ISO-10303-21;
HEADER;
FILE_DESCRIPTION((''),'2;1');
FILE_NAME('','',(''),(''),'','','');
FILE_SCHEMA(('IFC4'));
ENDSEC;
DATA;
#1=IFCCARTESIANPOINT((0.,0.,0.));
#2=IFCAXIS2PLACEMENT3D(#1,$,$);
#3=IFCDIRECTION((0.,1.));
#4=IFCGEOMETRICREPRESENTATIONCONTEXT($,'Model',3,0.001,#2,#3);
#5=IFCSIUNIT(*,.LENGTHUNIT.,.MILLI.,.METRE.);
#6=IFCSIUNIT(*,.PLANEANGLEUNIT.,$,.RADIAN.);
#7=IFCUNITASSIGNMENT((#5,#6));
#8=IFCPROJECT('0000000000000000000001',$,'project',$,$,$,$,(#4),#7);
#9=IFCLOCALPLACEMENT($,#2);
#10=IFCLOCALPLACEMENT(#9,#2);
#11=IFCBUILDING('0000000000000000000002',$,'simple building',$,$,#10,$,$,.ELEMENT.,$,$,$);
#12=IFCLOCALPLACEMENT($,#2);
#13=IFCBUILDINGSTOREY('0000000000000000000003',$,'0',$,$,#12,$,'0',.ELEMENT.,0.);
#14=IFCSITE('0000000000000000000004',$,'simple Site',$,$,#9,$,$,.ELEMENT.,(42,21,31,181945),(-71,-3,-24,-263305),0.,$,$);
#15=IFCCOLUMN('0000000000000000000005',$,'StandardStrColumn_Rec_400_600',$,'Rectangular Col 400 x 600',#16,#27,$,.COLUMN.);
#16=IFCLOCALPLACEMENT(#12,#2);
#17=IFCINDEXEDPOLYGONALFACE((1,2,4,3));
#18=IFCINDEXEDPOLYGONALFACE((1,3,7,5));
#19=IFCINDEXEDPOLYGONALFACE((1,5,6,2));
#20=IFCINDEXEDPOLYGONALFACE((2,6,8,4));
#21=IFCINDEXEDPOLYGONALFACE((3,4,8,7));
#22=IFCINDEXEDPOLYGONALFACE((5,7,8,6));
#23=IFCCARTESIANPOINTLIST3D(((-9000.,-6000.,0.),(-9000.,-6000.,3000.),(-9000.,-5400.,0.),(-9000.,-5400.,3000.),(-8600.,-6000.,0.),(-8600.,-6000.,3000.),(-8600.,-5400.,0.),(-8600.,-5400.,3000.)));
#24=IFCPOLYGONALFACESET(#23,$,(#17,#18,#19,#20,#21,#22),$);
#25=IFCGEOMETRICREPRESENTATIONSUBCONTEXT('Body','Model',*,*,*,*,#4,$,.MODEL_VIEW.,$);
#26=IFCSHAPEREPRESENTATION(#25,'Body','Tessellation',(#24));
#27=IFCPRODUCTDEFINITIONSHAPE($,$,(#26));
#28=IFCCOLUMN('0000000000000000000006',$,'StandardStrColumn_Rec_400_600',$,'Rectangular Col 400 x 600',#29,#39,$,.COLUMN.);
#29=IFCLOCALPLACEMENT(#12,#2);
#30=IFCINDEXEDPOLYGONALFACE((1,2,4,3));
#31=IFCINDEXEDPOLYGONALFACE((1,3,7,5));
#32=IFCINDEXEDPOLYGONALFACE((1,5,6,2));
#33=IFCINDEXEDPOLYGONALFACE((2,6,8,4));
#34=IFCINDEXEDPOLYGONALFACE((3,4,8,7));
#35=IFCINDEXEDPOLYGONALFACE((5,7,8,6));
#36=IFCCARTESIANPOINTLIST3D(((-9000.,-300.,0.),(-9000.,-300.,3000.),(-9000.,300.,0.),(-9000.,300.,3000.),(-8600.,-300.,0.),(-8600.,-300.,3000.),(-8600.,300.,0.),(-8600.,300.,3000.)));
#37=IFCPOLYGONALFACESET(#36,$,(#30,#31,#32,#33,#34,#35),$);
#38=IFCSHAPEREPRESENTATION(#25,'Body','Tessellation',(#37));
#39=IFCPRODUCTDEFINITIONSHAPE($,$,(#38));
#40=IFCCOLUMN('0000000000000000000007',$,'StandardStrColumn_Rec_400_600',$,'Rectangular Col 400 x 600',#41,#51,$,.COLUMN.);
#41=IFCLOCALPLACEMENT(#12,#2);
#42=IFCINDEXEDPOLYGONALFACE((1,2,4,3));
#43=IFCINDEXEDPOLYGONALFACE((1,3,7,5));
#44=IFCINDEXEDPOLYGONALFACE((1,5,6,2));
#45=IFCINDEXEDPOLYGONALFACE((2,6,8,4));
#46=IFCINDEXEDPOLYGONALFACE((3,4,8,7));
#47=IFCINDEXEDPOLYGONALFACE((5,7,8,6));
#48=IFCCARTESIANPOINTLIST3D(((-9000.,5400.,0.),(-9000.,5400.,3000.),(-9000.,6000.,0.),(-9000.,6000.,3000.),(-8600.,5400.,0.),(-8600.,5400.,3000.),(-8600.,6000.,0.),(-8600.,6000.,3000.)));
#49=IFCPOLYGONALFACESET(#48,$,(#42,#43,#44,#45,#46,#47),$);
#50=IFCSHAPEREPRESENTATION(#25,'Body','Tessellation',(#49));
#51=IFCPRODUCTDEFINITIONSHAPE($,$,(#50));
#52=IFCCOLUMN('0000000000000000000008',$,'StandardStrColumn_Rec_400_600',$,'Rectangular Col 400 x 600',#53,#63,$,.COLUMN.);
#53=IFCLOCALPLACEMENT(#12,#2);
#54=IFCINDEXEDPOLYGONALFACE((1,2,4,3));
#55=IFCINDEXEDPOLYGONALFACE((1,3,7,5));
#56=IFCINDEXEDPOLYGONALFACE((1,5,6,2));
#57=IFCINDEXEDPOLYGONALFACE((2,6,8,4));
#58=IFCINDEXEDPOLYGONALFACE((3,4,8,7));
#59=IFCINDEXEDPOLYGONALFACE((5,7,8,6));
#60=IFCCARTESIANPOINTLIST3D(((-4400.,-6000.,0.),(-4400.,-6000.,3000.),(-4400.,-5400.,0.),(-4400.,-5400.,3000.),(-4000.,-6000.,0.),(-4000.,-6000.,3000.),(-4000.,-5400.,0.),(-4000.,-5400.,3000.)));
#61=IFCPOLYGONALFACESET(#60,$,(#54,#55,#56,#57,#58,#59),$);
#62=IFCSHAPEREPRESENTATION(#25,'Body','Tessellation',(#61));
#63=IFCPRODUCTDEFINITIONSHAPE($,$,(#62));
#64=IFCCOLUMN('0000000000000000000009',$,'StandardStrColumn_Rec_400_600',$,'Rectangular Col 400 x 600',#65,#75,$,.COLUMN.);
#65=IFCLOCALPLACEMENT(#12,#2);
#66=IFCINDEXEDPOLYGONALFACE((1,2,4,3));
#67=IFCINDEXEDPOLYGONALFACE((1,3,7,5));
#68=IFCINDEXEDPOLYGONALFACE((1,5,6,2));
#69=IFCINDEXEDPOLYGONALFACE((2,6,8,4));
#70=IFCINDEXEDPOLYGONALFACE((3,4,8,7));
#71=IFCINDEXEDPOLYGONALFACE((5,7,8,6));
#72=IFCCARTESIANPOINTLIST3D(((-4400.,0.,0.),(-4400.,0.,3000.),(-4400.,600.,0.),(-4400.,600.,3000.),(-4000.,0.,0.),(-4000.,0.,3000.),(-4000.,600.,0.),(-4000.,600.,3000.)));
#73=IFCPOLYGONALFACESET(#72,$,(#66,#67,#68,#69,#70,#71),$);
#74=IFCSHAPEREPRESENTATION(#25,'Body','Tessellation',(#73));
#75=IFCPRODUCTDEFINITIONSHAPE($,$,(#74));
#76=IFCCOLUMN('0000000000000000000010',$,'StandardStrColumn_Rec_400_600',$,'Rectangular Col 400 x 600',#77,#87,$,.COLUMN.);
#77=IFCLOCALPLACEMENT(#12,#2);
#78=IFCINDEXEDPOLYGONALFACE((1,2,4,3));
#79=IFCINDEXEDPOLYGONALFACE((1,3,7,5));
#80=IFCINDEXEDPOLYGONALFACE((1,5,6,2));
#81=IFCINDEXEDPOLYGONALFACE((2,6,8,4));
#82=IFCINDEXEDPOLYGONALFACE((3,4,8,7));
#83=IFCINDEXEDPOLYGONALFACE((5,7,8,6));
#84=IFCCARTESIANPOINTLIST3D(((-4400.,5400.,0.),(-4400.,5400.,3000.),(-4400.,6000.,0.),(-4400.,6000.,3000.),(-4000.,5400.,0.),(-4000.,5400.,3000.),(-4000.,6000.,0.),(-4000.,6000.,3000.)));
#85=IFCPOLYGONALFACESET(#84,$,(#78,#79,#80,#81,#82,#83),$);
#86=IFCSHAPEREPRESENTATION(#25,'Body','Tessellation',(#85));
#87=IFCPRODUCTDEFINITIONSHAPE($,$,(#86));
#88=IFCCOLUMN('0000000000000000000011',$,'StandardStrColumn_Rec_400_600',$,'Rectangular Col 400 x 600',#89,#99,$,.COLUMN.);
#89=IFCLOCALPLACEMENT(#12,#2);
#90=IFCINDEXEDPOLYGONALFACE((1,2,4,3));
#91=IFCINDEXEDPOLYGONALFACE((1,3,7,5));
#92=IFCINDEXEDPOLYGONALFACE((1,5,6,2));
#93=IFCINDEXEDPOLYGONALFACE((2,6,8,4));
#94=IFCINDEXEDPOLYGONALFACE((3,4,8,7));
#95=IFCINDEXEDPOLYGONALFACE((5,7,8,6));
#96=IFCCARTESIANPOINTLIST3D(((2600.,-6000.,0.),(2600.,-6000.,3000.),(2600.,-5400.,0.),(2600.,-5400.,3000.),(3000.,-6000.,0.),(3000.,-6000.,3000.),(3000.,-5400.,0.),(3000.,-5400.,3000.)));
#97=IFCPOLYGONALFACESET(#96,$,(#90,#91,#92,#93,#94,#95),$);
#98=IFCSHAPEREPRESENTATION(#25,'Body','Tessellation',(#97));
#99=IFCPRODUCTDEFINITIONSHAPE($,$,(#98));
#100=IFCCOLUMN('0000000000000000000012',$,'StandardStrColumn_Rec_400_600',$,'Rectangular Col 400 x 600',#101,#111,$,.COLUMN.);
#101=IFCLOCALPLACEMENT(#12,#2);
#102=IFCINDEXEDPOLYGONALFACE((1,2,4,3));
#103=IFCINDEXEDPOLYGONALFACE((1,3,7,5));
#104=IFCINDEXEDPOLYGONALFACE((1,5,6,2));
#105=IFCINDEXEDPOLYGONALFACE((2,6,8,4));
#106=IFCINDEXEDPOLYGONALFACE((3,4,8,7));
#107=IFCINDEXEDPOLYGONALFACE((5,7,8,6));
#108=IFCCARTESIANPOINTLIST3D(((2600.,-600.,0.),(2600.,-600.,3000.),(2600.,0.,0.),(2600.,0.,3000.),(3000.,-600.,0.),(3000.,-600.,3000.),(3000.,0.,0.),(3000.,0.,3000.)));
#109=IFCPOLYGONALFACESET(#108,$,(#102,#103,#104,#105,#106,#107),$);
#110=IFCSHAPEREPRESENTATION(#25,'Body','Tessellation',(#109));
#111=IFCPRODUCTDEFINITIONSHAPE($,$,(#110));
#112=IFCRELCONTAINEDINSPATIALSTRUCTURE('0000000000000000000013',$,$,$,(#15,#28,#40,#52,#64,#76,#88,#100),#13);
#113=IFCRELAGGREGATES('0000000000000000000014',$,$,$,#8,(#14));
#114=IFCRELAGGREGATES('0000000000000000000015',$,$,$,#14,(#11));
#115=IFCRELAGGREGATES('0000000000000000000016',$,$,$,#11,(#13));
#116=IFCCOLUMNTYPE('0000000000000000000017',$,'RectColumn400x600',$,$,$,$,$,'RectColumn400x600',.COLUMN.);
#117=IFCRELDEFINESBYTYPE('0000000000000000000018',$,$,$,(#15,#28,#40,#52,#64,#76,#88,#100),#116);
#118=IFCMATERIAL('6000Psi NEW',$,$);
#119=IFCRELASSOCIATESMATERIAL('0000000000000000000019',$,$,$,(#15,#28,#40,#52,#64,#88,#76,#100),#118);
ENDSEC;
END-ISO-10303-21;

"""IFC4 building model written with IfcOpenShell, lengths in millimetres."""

from ifc_helpers import new_model, si_unit, direction, frame, origin, origin_with_axes, origin_2d_with_axis, place, context, subcontext, project, spatial, rectangle, extrude, material, material_profile, profile_set, profile_usage, type_object, element, save


model = new_model("IFC4")

# Units and contexts
model_context = context("Model", 3, precision=0.001, world=origin(), true_north=direction((0.0, 1.0)))
body_context = subcontext(model_context, "Body", "Model", "MODEL_VIEW")
ifc_project = project(units=[si_unit("LENGTHUNIT", "METRE", prefix="MILLI"), si_unit("PLANEANGLEUNIT", "RADIAN")], contexts=[model_context])

# Site, building, storey
site_placement = place(None, origin())
site = spatial("IfcSite", under=ifc_project, at=site_placement, Name="simple Site", CompositionType="ELEMENT", RefLatitude=(42, 21, 31, 181945), RefLongitude=(-71, -3, -24, -263305), RefElevation=0.0)
building_placement = place(site_placement, origin())
building = spatial("IfcBuilding", under=site, at=building_placement, Name="simple building", CompositionType="ELEMENT")
storey_placement = place(None, origin())
storey = spatial("IfcBuildingStorey", under=building, at=storey_placement, Name="0", LongName="0", CompositionType="ELEMENT", Elevation=0.0)

# Columns
ifc_material = material(Name="6000Psi NEW")
ifc_material_profile = material_profile(ifc_material, rectangle(XDim=400.0, YDim=600.0, at=origin_2d_with_axis()))
ifc_profile_set = profile_set([ifc_material_profile])
ifc_profile_usage_1 = profile_usage(ifc_profile_set, cardinal=7)
column_type = type_object("IfcColumnType", Name="RectColumn400x600", ElementType="RectColumn400x600", PredefinedType="COLUMN")
column_1_placement = place(None, frame((-8800.0, -5700.0, 0.0), z_axis=(0.0, 0.0, 1.0), x_axis=(1.0, 0.0, 0.0)))
element("IfcColumn", 1, at=column_1_placement, inside=storey, type_object=column_type, material=ifc_profile_usage_1, Name="StandardStrColumn_Rec_400_600", ObjectType="Rectangular Col 400 x 600", PredefinedType="COLUMN", context=body_context, shape_type="SweptSolid", body=[
    extrude(rectangle(XDim=400.0, YDim=600.0, at=origin_2d_with_axis()), origin_with_axes(), (0.0, 0.0, 1.0), 3000.0),
])
ifc_profile_usage_2 = profile_usage(ifc_profile_set, cardinal=4)
column_2_placement = place(None, frame((-8800.0, 0.0, 0.0), z_axis=(0.0, 0.0, 1.0), x_axis=(1.0, 0.0, 0.0)))
element("IfcColumn", 2, at=column_2_placement, inside=storey, type_object=column_type, material=ifc_profile_usage_2, Name="StandardStrColumn_Rec_400_600", ObjectType="Rectangular Col 400 x 600", PredefinedType="COLUMN", context=body_context, shape_type="SweptSolid", body=[
    extrude(rectangle(XDim=400.0, YDim=600.0, at=origin_2d_with_axis()), origin_with_axes(), (0.0, 0.0, 1.0), 3000.0),
])
ifc_profile_usage_3 = profile_usage(ifc_profile_set, cardinal=1)
column_3_placement = place(None, frame((-8800.0, 5700.0, 0.0), z_axis=(0.0, 0.0, 1.0), x_axis=(1.0, 0.0, 0.0)))
element("IfcColumn", 3, at=column_3_placement, inside=storey, type_object=column_type, material=ifc_profile_usage_3, Name="StandardStrColumn_Rec_400_600", ObjectType="Rectangular Col 400 x 600", PredefinedType="COLUMN", context=body_context, shape_type="SweptSolid", body=[
    extrude(rectangle(XDim=400.0, YDim=600.0, at=origin_2d_with_axis()), origin_with_axes(), (0.0, 0.0, 1.0), 3000.0),
])
ifc_profile_usage_4 = profile_usage(ifc_profile_set, cardinal=9)
for number, where, z_axis, x_axis, name in (
    (4, (-4200.0, -5700.0, 0.0), (0.0, 0.0, 1.0), (1.0, 0.0, 0.0), "StandardStrColumn_Rec_400_600"),
    (5, (-4200.0, 300.0, 0.0), (0.0, 0.0, 1.0), (1.0, 0.0, 0.0), "StandardStrColumn_Rec_400_600"),
):
    element("IfcColumn", number, at=place(None, frame(where, z_axis=z_axis, x_axis=x_axis)), inside=storey, type_object=column_type, material=ifc_profile_usage_4, Name=name, ObjectType="Rectangular Col 400 x 600", PredefinedType="COLUMN", context=body_context, shape_type="SweptSolid", body=[
        extrude(rectangle(XDim=400.0, YDim=600.0, at=origin_2d_with_axis()), origin_with_axes(), (0.0, 0.0, 1.0), 3000.0),
    ])
ifc_profile_usage_5 = profile_usage(ifc_profile_set, cardinal=3)
column_4_placement = place(None, frame((-4200.0, 5700.0, 0.0), z_axis=(0.0, 0.0, 1.0), x_axis=(1.0, 0.0, 0.0)))
element("IfcColumn", 6, at=column_4_placement, inside=storey, type_object=column_type, material=ifc_profile_usage_5, Name="StandardStrColumn_Rec_400_600", ObjectType="Rectangular Col 400 x 600", PredefinedType="COLUMN", context=body_context, shape_type="SweptSolid", body=[
    extrude(rectangle(XDim=400.0, YDim=600.0, at=origin_2d_with_axis()), origin_with_axes(), (0.0, 0.0, 1.0), 3000.0),
])
column_5_placement = place(None, frame((2800.0, -5700.0, 0.0), z_axis=(0.0, 0.0, 1.0), x_axis=(1.0, 0.0, 0.0)))
element("IfcColumn", 7, at=column_5_placement, inside=storey, type_object=column_type, material=ifc_profile_usage_4, Name="StandardStrColumn_Rec_400_600", ObjectType="Rectangular Col 400 x 600", PredefinedType="COLUMN", context=body_context, shape_type="SweptSolid", body=[
    extrude(rectangle(XDim=400.0, YDim=600.0, at=origin_2d_with_axis()), origin_with_axes(), (0.0, 0.0, 1.0), 3000.0),
])
column_6_placement = place(None, frame((2800.0, -300.0, 0.0), z_axis=(0.0, 0.0, 1.0), x_axis=(1.0, 0.0, 0.0)))
element("IfcColumn", 8, at=column_6_placement, inside=storey, type_object=column_type, material=ifc_profile_usage_5, Name="StandardStrColumn_Rec_400_600", ObjectType="Rectangular Col 400 x 600", PredefinedType="COLUMN", context=body_context, shape_type="SweptSolid", body=[
    extrude(rectangle(XDim=400.0, YDim=600.0, at=origin_2d_with_axis()), origin_with_axes(), (0.0, 0.0, 1.0), 3000.0),
])

save(model, "model.ifc")
